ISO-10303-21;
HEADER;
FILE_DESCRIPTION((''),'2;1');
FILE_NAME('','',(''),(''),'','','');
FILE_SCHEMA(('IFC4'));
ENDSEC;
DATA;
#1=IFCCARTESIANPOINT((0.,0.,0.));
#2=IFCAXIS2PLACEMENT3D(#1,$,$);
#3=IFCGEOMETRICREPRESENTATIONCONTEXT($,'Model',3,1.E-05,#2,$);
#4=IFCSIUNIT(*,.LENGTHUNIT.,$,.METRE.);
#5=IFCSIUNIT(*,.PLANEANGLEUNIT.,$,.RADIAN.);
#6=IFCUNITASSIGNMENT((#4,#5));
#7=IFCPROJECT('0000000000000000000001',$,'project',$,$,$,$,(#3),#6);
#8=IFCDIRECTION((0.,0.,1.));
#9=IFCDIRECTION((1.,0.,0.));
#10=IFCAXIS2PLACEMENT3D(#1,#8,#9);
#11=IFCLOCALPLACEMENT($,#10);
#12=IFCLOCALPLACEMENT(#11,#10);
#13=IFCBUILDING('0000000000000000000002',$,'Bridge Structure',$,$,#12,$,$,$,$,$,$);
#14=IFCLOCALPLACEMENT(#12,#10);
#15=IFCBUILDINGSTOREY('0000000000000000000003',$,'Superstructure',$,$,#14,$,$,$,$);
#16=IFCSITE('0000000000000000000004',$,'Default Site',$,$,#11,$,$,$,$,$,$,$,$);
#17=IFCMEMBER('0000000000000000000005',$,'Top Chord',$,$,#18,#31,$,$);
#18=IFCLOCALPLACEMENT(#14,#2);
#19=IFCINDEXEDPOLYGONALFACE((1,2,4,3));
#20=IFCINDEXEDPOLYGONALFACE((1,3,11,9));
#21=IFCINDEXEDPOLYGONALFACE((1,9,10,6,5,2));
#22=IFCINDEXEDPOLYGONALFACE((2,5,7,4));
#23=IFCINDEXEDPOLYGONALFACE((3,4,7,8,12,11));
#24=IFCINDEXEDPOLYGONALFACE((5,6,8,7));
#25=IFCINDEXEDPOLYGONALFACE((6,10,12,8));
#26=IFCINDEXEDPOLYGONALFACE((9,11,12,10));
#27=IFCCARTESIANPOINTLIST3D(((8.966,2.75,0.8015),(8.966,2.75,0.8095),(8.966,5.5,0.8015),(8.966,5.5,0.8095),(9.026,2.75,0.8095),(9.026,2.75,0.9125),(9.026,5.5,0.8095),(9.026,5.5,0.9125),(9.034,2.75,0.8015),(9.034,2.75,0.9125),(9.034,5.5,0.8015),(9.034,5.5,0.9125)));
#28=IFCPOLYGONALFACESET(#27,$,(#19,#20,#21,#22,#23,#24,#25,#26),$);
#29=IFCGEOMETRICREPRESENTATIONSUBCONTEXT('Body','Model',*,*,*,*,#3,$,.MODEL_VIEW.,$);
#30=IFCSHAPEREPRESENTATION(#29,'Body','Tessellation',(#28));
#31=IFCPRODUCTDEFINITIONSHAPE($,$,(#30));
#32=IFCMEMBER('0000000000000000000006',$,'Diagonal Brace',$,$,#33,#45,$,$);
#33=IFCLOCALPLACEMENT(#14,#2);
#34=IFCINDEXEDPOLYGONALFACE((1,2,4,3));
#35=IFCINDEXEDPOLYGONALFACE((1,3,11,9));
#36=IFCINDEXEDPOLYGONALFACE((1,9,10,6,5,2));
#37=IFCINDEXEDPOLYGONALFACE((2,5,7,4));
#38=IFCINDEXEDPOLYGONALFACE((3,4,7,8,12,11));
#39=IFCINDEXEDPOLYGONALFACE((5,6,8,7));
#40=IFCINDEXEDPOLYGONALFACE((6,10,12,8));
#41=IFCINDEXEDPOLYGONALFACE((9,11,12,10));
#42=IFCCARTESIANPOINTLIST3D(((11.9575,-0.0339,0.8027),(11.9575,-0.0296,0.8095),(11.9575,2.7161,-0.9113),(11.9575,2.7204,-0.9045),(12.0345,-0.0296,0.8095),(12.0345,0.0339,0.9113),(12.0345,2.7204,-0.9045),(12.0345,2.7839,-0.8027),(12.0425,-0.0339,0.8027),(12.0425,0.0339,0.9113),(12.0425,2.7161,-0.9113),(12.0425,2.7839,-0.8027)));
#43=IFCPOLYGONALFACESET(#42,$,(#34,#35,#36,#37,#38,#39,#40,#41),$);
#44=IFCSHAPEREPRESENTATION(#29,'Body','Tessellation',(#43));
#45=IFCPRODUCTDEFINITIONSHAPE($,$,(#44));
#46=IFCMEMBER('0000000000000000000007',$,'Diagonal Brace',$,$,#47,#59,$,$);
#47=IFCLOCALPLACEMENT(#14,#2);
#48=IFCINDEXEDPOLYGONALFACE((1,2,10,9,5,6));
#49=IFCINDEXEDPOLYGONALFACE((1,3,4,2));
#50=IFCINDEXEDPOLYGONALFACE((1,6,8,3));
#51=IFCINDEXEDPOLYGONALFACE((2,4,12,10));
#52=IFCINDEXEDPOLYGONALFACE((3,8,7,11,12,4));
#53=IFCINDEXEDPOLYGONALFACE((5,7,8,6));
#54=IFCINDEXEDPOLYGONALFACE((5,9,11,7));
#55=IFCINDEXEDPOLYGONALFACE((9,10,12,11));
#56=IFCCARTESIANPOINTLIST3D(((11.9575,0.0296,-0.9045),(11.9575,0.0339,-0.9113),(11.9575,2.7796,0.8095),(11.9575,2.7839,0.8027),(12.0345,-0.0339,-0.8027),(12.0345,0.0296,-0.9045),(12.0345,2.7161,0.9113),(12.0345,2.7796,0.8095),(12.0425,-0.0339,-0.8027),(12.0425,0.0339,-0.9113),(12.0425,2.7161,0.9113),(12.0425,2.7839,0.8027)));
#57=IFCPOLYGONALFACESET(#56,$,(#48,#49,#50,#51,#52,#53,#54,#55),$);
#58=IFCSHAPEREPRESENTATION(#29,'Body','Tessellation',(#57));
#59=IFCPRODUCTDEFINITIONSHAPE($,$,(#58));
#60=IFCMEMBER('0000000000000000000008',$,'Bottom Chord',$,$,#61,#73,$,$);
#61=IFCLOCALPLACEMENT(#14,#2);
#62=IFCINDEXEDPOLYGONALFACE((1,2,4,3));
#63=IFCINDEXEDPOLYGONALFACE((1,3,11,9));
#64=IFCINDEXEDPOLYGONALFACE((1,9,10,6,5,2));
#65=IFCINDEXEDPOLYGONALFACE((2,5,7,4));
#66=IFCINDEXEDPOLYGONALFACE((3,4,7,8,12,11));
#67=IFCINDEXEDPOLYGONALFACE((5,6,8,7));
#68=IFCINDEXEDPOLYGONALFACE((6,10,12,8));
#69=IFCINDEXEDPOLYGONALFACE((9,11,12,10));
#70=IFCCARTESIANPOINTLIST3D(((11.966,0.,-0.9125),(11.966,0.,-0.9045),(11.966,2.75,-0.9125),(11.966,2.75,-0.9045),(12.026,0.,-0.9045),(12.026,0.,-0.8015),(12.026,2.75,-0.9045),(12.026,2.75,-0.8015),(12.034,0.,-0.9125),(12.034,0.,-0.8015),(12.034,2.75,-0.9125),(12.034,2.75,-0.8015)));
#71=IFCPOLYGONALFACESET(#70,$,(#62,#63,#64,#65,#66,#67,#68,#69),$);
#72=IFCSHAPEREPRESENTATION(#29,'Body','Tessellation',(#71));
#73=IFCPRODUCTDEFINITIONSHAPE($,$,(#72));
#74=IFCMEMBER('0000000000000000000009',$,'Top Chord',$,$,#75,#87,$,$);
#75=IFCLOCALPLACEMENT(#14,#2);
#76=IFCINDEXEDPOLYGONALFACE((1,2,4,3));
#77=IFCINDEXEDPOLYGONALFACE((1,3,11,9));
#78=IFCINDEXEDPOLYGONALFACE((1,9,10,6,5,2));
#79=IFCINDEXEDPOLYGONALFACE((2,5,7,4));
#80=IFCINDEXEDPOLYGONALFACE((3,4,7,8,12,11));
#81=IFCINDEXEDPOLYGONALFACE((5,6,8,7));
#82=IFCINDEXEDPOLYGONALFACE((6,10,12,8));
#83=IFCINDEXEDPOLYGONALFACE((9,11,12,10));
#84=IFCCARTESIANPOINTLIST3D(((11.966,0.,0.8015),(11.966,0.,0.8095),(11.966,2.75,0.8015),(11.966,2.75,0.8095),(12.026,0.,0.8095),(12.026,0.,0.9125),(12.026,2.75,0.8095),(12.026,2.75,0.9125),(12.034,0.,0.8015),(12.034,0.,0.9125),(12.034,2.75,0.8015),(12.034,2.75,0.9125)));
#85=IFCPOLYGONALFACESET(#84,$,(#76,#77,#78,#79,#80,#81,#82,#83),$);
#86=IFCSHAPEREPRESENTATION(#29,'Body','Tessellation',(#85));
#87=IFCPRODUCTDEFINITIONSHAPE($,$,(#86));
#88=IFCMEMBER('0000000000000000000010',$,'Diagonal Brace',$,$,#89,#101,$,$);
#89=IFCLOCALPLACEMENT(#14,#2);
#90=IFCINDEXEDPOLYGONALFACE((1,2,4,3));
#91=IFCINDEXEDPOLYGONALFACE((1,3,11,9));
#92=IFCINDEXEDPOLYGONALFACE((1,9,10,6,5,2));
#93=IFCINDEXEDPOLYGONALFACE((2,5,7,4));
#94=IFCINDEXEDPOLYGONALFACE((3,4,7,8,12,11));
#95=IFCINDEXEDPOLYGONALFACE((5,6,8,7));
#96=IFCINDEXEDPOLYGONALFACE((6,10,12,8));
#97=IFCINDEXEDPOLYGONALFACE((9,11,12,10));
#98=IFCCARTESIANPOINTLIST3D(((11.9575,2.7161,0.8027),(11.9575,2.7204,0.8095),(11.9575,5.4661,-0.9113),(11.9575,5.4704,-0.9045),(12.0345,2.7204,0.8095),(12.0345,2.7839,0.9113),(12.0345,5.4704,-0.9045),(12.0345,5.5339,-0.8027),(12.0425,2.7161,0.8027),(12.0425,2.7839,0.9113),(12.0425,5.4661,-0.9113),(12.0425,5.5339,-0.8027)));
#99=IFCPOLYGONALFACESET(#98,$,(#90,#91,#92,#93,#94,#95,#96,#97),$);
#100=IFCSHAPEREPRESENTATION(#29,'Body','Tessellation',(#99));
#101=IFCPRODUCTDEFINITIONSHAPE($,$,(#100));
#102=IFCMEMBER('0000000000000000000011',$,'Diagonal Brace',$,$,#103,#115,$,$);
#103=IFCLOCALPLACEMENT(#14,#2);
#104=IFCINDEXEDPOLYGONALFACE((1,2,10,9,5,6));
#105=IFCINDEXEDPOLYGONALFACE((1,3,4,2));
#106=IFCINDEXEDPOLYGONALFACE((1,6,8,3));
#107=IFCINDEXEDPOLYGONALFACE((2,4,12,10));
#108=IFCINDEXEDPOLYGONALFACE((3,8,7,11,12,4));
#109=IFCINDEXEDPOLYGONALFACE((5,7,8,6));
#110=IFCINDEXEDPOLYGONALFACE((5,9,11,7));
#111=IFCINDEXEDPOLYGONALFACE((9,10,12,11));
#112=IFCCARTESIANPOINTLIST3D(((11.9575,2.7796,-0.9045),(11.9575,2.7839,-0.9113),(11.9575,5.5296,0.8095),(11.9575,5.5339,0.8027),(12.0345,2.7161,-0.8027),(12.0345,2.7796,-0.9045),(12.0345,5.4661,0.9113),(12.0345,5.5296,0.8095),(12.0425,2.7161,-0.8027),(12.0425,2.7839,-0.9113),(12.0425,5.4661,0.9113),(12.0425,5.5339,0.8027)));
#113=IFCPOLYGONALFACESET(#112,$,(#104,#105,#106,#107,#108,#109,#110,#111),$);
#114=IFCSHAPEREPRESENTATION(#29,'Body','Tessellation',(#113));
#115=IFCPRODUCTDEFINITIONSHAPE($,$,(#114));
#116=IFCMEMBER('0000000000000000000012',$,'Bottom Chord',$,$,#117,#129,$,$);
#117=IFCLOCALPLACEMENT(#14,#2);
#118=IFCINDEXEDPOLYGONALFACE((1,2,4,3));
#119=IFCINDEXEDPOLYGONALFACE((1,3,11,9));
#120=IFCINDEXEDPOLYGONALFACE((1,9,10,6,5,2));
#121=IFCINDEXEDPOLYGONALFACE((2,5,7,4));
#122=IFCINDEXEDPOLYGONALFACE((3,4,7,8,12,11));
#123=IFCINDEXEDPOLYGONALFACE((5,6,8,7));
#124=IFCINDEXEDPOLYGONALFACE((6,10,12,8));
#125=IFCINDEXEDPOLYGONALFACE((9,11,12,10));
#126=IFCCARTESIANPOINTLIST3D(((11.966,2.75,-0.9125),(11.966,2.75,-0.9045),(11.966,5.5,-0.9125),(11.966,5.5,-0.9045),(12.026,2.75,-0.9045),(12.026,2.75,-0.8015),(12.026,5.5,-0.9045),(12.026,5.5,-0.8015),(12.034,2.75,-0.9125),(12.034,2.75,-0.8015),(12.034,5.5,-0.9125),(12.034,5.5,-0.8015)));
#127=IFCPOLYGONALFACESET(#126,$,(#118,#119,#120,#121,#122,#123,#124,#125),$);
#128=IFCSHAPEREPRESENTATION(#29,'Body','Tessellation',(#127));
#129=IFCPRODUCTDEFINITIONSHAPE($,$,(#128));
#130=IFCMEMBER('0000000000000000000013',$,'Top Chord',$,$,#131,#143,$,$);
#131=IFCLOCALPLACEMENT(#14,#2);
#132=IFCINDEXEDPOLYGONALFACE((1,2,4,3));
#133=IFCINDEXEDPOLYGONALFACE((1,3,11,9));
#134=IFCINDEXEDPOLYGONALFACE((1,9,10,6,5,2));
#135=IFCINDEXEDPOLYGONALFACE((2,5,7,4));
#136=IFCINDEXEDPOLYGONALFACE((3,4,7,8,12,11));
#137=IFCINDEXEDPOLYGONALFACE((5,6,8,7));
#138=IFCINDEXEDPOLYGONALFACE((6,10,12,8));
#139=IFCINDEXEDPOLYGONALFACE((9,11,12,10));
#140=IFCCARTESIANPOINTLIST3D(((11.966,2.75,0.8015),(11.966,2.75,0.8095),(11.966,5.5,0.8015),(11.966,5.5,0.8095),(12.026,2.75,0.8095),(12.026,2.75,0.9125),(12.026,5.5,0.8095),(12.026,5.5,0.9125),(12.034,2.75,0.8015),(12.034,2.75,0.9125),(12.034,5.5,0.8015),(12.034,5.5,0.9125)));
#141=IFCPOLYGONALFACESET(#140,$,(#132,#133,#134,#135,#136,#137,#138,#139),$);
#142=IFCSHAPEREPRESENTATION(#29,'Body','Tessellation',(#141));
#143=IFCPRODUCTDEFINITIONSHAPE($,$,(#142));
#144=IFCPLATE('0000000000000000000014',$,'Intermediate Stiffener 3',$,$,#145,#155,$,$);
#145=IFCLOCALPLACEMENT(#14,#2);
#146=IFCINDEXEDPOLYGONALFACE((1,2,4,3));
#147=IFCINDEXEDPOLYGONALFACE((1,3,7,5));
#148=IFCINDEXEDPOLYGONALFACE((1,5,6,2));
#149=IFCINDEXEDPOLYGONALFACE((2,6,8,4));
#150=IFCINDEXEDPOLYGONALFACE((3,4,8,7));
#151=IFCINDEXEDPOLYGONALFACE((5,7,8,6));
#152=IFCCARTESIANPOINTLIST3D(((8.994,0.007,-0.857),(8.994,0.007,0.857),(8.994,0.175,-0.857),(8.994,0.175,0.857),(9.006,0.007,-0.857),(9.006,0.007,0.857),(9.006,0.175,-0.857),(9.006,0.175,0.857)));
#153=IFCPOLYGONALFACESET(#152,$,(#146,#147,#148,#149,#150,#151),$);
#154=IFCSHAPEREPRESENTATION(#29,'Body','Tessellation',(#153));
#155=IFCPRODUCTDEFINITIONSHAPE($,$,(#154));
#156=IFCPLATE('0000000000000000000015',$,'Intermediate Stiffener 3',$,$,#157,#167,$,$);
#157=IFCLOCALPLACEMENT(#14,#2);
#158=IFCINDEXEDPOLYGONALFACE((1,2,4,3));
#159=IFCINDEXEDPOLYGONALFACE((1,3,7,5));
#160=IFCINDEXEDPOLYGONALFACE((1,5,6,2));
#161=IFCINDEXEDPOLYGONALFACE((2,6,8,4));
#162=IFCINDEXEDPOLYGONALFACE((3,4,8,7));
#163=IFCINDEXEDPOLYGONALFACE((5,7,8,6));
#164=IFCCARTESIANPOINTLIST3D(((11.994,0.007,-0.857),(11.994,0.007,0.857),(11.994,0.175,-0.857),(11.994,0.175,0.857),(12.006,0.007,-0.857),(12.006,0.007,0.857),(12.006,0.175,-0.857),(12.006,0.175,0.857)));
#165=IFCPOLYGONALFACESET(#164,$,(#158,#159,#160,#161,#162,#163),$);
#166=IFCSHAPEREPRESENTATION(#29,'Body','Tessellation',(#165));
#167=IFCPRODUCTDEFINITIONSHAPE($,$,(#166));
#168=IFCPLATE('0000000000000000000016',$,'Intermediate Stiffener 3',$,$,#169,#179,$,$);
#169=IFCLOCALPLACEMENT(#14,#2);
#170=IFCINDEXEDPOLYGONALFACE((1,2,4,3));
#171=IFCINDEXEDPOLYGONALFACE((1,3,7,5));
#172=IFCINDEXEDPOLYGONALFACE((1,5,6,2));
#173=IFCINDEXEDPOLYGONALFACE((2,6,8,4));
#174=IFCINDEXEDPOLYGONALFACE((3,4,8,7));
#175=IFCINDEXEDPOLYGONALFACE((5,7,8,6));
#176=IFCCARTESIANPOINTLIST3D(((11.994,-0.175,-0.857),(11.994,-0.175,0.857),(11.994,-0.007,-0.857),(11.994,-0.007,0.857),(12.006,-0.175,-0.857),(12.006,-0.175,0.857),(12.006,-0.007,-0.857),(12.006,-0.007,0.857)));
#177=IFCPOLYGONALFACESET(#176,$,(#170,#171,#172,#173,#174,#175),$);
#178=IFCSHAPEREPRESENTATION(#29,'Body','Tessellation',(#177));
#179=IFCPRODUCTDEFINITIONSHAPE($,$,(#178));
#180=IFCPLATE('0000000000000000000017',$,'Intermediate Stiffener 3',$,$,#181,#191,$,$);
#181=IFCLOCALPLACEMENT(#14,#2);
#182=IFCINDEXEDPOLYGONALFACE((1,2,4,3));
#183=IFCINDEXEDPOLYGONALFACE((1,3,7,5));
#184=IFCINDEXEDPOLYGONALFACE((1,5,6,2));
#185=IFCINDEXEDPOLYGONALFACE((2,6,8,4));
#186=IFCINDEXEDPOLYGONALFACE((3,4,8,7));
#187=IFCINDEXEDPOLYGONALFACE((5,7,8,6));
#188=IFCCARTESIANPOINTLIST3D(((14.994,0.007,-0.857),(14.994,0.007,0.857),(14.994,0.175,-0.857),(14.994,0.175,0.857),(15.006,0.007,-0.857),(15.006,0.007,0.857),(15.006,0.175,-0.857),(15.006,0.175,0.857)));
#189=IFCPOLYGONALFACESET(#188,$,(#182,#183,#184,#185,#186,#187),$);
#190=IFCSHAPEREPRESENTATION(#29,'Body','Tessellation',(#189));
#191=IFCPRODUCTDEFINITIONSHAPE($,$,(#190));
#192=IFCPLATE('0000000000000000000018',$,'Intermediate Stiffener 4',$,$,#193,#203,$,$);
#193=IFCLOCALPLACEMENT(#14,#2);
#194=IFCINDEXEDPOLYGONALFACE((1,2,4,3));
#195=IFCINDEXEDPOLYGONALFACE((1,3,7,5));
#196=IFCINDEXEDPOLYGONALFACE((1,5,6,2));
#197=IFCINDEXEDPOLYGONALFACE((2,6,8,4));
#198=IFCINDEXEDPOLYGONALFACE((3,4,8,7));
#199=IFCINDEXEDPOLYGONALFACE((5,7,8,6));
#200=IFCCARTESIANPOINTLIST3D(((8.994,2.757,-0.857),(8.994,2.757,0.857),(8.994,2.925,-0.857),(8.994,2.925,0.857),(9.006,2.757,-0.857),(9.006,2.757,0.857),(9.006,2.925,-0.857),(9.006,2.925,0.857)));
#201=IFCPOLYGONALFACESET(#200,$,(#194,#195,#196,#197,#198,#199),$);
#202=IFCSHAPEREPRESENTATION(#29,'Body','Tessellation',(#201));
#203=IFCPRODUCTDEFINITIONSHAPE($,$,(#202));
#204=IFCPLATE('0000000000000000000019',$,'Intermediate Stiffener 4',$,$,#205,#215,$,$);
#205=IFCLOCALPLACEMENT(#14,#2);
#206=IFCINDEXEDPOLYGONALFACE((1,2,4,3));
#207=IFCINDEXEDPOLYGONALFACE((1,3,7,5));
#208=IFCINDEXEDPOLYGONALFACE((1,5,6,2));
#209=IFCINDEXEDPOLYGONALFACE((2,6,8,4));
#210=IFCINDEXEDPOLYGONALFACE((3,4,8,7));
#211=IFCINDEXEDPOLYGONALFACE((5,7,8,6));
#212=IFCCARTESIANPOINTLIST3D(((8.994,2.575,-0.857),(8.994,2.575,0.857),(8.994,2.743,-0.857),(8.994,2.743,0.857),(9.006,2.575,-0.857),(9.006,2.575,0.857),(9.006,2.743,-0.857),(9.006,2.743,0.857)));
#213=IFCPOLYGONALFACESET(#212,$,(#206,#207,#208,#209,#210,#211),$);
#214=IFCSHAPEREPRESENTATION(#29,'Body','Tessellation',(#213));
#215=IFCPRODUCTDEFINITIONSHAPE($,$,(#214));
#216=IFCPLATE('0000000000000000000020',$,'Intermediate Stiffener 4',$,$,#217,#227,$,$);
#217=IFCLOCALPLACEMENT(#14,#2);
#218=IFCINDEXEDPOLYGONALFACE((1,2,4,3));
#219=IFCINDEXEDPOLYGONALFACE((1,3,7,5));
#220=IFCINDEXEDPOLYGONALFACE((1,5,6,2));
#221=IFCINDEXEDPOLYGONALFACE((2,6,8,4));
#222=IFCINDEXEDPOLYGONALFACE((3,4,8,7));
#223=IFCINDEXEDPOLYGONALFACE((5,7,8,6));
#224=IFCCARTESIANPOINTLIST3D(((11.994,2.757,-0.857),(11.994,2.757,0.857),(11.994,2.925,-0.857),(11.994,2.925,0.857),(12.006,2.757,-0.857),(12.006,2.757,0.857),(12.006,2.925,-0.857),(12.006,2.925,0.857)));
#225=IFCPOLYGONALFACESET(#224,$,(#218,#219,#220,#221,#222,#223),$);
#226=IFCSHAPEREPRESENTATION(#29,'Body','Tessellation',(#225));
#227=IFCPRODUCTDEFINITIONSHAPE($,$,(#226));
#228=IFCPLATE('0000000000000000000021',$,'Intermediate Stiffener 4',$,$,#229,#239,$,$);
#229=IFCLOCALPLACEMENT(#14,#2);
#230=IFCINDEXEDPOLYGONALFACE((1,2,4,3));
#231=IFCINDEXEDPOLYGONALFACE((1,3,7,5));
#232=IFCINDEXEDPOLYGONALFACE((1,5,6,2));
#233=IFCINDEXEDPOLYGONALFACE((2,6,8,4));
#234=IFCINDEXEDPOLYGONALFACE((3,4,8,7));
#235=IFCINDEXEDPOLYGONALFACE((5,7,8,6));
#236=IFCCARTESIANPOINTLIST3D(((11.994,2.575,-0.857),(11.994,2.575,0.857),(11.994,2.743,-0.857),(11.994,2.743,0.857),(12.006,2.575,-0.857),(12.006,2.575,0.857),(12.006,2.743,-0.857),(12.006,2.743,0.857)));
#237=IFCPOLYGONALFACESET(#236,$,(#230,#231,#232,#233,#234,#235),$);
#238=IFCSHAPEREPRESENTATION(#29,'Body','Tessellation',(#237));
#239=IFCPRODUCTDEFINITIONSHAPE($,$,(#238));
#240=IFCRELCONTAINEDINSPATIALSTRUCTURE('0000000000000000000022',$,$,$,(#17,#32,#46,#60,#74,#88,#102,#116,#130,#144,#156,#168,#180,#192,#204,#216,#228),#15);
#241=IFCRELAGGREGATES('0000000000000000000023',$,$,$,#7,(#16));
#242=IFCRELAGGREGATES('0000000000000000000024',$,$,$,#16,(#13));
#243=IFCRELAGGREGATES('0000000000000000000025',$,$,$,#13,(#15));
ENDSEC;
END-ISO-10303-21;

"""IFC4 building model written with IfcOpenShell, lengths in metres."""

from ifc_helpers import new_model, si_unit, frame, origin, origin_with_axes, origin_2d_with_axis, place, context, subcontext, project, spatial, rectangle, l_section, extrude, element, save


model = new_model("IFC4")

# Units and contexts
model_context = context("Model", 3, precision=1e-05, world=origin())
body_context = subcontext(model_context, "Body", "Model", "MODEL_VIEW")
ifc_project = project(units=[si_unit("LENGTHUNIT", "METRE"), si_unit("PLANEANGLEUNIT", "RADIAN")], contexts=[model_context])

# Site, building, storey
site_placement = place(None, origin_with_axes())
site = spatial("IfcSite", under=ifc_project, at=site_placement, Name="Default Site")
building_placement = place(site_placement, origin_with_axes())
building = spatial("IfcBuilding", under=site, at=building_placement, Name="Bridge Structure")
storey_placement = place(building_placement, origin_with_axes())
storey = spatial("IfcBuildingStorey", under=building, at=storey_placement, Name="Superstructure")

# Members
for number, where, z_axis, x_axis, name in (
    (1, (9.0, 2.75, 0.857), (0.0, 1.0, 0.0), (-1.0, 0.0, 0.0), "Top Chord"),
):
    element("IfcMember", number, at=place(storey_placement, frame(where, z_axis=z_axis, x_axis=x_axis)), inside=storey, Name=name, context=body_context, shape_type="SweptSolid", body=[
        extrude(l_section(Depth=0.111, Width=0.068, Thickness=0.008, at=origin_2d_with_axis()), origin_with_axes(), (0.0, 0.0, 1.0), 2.75),
    ])
for number, where, z_axis, x_axis, name in (
    (2, (12.0, 0.0, 0.857), (0.0, 0.848656, -0.528944), (-1.0, 0.0, 0.0), "Diagonal Brace"),
    (3, (12.0, 0.0, -0.857), (0.0, 0.848656, 0.528944), (-1.0, 0.0, 0.0), "Diagonal Brace"),
):
    element("IfcMember", number, at=place(storey_placement, frame(where, z_axis=z_axis, x_axis=x_axis)), inside=storey, Name=name, context=body_context, shape_type="SweptSolid", body=[
        extrude(l_section(Depth=0.128, Width=0.085, Thickness=0.008, at=origin_2d_with_axis()), origin_with_axes(), (0.0, 0.0, 1.0), 3.2404),
    ])
for number, where, z_axis, x_axis, name in (
    (4, (12.0, 0.0, -0.857), (0.0, 1.0, 0.0), (-1.0, 0.0, 0.0), "Bottom Chord"),
    (5, (12.0, 0.0, 0.857), (0.0, 1.0, 0.0), (-1.0, 0.0, 0.0), "Top Chord"),
):
    element("IfcMember", number, at=place(storey_placement, frame(where, z_axis=z_axis, x_axis=x_axis)), inside=storey, Name=name, context=body_context, shape_type="SweptSolid", body=[
        extrude(l_section(Depth=0.111, Width=0.068, Thickness=0.008, at=origin_2d_with_axis()), origin_with_axes(), (0.0, 0.0, 1.0), 2.75),
    ])
for number, where, z_axis, x_axis, name in (
    (6, (12.0, 2.75, 0.857), (0.0, 0.848656, -0.528944), (-1.0, 0.0, 0.0), "Diagonal Brace"),
    (7, (12.0, 2.75, -0.857), (0.0, 0.848656, 0.528944), (-1.0, 0.0, 0.0), "Diagonal Brace"),
):
    element("IfcMember", number, at=place(storey_placement, frame(where, z_axis=z_axis, x_axis=x_axis)), inside=storey, Name=name, context=body_context, shape_type="SweptSolid", body=[
        extrude(l_section(Depth=0.128, Width=0.085, Thickness=0.008, at=origin_2d_with_axis()), origin_with_axes(), (0.0, 0.0, 1.0), 3.2404),
    ])
for number, where, z_axis, x_axis, name in (
    (8, (12.0, 2.75, -0.857), (0.0, 1.0, 0.0), (-1.0, 0.0, 0.0), "Bottom Chord"),
    (9, (12.0, 2.75, 0.857), (0.0, 1.0, 0.0), (-1.0, 0.0, 0.0), "Top Chord"),
):
    element("IfcMember", number, at=place(storey_placement, frame(where, z_axis=z_axis, x_axis=x_axis)), inside=storey, Name=name, context=body_context, shape_type="SweptSolid", body=[
        extrude(l_section(Depth=0.111, Width=0.068, Thickness=0.008, at=origin_2d_with_axis()), origin_with_axes(), (0.0, 0.0, 1.0), 2.75),
    ])

# Plates
for number, where, z_axis, x_axis, name in (
    (10, (9.0, 0.091, -0.857), (0.0, 0.0, 1.0), (1.0, 0.0, 0.0), "Intermediate Stiffener 3"),
    (11, (12.0, 0.091, -0.857), (0.0, 0.0, 1.0), (1.0, 0.0, 0.0), "Intermediate Stiffener 3"),
    (12, (12.0, -0.091, -0.857), (0.0, 0.0, 1.0), (1.0, 0.0, 0.0), "Intermediate Stiffener 3"),
    (13, (15.0, 0.091, -0.857), (0.0, 0.0, 1.0), (1.0, 0.0, 0.0), "Intermediate Stiffener 3"),
    (14, (9.0, 2.841, -0.857), (0.0, 0.0, 1.0), (1.0, 0.0, 0.0), "Intermediate Stiffener 4"),
    (15, (9.0, 2.659, -0.857), (0.0, 0.0, 1.0), (1.0, 0.0, 0.0), "Intermediate Stiffener 4"),
    (16, (12.0, 2.841, -0.857), (0.0, 0.0, 1.0), (1.0, 0.0, 0.0), "Intermediate Stiffener 4"),
    (17, (12.0, 2.659, -0.857), (0.0, 0.0, 1.0), (1.0, 0.0, 0.0), "Intermediate Stiffener 4"),
):
    element("IfcPlate", number, at=place(storey_placement, frame(where, z_axis=z_axis, x_axis=x_axis)), inside=storey, Name=name, context=body_context, shape_type="SweptSolid", body=[
        extrude(rectangle(XDim=0.012, YDim=0.168, at=origin_2d_with_axis()), origin_with_axes(), (0.0, 0.0, 1.0), 1.714),
    ])

save(model, "model.ifc")
